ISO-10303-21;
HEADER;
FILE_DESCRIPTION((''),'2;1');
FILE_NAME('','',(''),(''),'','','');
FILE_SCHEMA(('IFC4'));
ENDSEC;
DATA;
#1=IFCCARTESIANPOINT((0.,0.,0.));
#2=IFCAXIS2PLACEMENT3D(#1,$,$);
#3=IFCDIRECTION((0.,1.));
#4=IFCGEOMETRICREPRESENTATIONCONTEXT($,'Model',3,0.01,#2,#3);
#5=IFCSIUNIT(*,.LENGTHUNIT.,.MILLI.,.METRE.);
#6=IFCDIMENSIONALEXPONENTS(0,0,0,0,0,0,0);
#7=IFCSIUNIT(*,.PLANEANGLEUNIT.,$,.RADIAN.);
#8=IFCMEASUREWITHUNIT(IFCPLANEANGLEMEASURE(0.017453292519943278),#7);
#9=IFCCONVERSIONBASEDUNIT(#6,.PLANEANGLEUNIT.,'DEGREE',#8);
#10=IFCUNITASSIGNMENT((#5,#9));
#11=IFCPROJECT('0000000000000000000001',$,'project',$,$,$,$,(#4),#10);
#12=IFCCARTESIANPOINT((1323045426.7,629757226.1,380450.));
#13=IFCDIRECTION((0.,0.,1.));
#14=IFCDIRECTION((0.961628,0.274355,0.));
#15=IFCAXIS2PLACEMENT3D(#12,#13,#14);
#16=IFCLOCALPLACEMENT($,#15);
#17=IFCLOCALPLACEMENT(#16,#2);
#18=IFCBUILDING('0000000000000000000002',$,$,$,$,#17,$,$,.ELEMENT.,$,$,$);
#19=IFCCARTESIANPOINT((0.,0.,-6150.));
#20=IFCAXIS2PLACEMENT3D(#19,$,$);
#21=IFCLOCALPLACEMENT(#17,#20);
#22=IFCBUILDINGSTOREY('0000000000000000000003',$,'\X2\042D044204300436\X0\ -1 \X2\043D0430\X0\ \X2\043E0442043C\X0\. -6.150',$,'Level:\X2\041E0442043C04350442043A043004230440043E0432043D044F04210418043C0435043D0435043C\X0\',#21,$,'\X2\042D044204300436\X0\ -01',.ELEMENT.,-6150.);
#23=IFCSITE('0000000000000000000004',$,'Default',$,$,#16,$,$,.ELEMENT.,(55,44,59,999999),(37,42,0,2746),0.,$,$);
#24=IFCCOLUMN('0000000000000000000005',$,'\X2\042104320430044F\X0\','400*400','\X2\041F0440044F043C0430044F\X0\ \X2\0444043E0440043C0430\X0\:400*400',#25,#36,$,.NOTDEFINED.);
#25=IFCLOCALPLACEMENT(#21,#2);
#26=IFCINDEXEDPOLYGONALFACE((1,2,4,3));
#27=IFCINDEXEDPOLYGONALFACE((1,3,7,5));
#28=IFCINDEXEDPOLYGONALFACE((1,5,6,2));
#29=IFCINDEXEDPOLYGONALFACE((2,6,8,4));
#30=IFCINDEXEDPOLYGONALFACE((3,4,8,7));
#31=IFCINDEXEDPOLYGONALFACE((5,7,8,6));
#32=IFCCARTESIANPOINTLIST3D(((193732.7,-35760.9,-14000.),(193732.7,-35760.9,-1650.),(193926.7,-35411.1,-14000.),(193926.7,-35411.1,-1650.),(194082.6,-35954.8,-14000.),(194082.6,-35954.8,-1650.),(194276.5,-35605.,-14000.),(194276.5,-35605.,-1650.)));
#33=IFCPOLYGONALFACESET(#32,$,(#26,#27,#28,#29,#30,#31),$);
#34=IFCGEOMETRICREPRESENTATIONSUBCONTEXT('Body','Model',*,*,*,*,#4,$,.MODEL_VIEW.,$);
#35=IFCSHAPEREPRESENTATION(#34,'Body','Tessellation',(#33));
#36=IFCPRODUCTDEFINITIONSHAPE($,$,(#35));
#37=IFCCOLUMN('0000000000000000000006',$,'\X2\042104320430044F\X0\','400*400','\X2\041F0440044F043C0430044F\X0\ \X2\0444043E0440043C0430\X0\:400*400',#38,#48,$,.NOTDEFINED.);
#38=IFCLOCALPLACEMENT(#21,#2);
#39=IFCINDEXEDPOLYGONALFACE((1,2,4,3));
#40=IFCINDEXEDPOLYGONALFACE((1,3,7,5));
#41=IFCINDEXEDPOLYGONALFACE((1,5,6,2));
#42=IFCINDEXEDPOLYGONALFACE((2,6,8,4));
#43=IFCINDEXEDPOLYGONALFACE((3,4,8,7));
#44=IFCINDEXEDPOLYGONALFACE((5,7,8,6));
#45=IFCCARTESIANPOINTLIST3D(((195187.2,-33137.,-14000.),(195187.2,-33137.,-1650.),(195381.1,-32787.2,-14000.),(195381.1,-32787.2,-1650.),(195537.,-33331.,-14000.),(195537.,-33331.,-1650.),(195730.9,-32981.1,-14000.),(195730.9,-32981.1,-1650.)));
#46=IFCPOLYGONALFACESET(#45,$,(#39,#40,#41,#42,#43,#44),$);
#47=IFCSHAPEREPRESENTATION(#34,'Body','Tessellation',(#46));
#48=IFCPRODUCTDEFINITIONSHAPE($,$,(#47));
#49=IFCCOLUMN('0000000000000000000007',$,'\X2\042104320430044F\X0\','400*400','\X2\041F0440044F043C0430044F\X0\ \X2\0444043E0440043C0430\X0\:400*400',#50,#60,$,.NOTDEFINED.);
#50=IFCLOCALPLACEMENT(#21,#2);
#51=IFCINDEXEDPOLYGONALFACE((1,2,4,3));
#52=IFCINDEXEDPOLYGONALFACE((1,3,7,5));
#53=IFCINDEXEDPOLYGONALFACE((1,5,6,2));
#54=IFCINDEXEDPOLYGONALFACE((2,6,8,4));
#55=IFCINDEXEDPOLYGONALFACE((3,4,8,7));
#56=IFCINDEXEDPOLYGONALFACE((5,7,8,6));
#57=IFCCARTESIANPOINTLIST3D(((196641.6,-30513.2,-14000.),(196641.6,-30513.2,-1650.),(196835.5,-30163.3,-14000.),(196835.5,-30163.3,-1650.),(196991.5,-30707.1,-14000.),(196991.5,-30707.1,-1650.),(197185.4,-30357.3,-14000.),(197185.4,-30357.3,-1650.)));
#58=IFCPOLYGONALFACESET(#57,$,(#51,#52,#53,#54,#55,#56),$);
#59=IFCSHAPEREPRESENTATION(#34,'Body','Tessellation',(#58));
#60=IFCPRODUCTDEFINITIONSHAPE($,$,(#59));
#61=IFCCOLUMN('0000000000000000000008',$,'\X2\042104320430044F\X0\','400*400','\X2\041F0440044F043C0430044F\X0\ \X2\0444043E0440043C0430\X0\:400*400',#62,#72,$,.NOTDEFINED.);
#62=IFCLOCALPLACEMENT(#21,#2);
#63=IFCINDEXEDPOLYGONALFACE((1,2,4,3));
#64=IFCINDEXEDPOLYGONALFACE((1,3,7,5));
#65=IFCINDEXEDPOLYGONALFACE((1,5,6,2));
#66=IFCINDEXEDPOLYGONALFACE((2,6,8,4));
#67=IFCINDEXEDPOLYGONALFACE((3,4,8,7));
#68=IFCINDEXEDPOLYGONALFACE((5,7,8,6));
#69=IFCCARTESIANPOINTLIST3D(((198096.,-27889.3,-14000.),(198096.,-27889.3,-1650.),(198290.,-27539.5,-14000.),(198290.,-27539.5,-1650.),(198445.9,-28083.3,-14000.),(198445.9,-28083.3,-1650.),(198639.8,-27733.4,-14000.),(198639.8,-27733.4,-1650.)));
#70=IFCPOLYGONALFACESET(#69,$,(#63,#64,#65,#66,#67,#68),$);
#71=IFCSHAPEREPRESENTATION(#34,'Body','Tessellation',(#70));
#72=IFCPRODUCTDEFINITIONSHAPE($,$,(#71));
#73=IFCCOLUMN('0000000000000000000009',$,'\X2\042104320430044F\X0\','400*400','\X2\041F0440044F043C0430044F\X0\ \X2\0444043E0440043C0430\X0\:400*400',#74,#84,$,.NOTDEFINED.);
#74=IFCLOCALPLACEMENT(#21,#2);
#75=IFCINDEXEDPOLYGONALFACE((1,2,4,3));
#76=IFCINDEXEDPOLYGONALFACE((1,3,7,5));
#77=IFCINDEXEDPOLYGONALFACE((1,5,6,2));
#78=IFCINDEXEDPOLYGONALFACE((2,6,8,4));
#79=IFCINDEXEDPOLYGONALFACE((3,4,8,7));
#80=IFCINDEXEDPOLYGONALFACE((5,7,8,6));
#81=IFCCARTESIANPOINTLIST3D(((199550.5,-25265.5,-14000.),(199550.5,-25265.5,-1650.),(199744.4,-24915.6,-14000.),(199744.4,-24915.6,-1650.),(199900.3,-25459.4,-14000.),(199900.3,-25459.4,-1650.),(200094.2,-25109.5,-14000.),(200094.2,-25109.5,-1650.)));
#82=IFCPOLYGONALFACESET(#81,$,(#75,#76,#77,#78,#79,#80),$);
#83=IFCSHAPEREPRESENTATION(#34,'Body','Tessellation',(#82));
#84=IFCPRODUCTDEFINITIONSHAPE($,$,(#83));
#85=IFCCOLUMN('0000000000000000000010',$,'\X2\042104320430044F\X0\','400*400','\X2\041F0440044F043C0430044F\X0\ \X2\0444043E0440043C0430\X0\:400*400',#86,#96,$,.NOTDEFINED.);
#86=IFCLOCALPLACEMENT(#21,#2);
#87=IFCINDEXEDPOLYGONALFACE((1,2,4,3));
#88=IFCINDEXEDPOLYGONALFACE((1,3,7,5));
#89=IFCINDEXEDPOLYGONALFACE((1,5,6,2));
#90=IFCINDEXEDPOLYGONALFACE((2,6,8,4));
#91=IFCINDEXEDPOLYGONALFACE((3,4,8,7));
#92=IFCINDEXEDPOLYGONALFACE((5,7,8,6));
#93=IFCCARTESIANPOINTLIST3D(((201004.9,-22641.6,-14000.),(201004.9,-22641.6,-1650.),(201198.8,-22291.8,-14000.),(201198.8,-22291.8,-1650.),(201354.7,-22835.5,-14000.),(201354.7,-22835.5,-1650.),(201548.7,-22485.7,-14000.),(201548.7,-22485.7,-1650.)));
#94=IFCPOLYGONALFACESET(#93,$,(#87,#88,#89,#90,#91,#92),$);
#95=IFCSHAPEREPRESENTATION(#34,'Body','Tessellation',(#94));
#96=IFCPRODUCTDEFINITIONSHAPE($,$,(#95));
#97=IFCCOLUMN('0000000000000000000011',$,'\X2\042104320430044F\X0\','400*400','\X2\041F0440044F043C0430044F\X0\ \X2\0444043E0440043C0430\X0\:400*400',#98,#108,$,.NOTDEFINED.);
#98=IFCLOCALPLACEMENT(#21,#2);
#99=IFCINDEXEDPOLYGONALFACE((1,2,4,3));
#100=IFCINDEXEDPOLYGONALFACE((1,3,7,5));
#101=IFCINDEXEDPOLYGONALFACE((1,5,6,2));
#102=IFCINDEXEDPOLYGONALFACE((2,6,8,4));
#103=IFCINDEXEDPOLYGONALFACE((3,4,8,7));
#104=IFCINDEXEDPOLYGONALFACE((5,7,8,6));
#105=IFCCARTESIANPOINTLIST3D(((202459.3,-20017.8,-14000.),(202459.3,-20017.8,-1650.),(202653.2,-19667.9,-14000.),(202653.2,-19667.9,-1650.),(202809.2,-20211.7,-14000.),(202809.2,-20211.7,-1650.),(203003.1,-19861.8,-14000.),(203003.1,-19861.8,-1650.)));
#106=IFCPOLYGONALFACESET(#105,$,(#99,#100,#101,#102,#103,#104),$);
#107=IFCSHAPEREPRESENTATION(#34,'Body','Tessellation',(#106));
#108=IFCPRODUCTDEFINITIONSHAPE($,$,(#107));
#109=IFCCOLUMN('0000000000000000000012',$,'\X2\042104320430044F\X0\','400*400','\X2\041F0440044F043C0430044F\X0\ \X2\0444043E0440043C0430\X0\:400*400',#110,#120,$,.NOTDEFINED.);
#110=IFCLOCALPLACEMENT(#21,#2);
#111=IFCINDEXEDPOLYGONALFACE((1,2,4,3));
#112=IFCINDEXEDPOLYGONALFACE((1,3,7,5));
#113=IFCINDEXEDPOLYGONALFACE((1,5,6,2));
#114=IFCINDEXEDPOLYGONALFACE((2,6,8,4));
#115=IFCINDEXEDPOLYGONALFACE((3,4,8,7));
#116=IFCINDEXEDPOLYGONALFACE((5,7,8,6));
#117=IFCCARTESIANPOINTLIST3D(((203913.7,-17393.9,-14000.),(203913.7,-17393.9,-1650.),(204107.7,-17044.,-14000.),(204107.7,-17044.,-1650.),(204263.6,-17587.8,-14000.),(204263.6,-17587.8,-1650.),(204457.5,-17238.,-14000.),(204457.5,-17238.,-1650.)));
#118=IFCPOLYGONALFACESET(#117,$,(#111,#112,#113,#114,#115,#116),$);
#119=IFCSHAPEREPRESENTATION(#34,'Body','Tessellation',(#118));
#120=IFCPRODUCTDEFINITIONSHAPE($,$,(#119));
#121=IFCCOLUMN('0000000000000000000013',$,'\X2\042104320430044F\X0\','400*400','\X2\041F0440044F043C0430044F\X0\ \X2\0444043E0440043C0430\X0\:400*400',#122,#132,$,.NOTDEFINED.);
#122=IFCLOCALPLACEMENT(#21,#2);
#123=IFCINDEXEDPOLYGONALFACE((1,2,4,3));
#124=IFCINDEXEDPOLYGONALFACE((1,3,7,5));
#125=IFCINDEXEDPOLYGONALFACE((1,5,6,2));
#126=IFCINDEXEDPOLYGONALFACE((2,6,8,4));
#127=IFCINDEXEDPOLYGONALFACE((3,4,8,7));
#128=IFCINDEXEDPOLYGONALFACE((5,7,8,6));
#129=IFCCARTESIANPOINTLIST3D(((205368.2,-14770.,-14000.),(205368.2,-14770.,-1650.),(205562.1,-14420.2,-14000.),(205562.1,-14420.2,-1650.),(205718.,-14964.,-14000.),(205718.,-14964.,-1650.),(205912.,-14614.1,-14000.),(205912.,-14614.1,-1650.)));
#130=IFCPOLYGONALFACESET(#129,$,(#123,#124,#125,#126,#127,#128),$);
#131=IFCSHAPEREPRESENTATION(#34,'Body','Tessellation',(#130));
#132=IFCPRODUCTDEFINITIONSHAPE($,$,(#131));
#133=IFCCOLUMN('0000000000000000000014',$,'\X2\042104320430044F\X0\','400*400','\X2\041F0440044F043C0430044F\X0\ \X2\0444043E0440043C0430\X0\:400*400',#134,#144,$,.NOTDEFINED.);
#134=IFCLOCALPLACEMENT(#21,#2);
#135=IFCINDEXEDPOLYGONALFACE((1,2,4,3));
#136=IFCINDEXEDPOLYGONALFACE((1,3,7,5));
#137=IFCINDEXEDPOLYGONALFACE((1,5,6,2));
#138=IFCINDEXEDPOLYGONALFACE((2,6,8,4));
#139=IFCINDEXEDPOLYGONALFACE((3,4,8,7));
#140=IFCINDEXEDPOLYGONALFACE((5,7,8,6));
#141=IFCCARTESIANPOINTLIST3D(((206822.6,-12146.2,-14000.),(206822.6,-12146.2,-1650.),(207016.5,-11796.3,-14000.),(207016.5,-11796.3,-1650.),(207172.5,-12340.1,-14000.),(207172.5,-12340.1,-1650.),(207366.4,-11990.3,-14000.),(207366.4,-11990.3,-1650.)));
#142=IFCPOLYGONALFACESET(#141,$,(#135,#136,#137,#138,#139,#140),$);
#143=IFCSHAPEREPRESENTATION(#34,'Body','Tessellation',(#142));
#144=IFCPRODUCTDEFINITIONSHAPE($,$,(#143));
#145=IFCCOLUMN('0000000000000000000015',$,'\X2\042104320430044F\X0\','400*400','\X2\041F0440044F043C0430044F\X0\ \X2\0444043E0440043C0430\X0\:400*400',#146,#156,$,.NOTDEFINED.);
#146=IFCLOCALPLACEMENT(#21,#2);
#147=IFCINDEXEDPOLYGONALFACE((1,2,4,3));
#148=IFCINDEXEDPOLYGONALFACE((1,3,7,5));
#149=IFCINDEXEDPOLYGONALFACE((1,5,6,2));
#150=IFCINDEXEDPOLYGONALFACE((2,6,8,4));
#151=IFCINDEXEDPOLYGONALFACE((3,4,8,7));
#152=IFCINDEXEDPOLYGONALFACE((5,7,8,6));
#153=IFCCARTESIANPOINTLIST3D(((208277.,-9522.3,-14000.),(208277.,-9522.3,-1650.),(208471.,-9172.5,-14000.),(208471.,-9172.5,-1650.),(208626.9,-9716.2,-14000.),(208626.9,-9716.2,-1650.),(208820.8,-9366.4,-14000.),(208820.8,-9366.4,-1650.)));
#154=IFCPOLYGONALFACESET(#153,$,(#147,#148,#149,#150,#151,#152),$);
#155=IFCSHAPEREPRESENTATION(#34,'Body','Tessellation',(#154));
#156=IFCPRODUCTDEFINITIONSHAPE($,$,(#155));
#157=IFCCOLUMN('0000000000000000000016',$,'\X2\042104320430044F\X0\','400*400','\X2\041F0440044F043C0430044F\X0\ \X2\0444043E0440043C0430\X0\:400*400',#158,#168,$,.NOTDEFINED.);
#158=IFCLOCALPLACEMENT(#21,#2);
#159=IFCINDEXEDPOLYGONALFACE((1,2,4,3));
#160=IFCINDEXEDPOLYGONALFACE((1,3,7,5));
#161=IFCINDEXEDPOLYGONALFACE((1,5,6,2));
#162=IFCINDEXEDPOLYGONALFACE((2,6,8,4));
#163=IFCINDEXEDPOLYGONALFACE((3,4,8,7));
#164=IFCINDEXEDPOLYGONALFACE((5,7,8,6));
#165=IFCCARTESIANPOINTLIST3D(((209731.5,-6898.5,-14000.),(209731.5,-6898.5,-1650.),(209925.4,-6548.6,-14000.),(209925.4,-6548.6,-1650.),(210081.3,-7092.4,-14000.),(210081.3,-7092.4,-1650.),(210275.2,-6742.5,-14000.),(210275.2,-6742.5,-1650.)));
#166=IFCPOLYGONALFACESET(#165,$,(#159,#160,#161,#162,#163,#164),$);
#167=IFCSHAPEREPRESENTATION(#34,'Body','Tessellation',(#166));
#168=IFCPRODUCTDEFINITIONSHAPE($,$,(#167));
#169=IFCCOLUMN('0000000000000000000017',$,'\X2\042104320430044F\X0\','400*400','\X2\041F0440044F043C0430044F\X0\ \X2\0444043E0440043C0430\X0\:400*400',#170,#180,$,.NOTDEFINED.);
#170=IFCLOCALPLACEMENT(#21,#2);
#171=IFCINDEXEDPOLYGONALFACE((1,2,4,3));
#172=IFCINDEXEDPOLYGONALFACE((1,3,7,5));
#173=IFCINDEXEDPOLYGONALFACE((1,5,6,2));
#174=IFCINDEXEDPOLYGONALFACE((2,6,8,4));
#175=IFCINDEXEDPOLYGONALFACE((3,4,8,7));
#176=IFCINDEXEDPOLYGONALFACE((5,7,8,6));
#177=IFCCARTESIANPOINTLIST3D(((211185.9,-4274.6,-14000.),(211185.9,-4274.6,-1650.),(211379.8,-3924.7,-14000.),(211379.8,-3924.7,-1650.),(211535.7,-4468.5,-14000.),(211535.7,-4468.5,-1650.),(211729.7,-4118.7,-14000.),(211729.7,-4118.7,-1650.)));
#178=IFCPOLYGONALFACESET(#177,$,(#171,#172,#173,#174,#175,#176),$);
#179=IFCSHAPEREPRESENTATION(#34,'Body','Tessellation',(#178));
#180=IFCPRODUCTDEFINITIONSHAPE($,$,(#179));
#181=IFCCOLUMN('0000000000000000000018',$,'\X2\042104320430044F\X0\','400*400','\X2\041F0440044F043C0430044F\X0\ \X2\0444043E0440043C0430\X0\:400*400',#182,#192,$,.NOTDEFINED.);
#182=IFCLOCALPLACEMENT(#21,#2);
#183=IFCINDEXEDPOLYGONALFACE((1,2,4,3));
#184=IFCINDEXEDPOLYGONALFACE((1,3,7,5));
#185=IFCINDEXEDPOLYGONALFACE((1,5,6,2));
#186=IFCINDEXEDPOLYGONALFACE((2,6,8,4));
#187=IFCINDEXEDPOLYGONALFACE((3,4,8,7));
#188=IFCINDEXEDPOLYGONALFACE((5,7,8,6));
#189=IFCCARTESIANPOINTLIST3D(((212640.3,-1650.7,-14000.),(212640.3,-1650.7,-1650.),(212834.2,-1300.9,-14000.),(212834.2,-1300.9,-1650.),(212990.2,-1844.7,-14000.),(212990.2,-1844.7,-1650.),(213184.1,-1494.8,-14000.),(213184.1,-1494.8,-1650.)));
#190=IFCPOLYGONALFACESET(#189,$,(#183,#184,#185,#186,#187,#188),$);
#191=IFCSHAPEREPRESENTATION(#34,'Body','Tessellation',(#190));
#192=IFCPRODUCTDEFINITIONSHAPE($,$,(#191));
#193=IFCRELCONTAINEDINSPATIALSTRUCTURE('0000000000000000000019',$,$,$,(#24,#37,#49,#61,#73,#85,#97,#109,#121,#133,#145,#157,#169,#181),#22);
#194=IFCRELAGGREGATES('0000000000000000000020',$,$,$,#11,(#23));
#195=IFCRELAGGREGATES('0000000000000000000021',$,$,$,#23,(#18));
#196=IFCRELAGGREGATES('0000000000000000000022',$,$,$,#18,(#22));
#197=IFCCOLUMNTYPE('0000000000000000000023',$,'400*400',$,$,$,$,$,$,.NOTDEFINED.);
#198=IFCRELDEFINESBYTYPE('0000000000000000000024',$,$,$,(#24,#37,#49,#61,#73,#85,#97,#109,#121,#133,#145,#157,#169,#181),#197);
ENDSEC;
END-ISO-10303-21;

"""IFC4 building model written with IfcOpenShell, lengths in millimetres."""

from ifc_helpers import new_model, entity, si_unit, converted_unit, direction, frame, origin, place, context, subcontext, project, spatial, indexed_curve, outline, extrude, type_object, element, save


model = new_model("IFC4")

# Units and contexts
model_context = context("Model", 3, precision=0.01, world=origin(), true_north=direction((0.0, 1.0)))
body_context = subcontext(model_context, "Body", "Model", "MODEL_VIEW")
ifc_project = project(units=[si_unit("LENGTHUNIT", "METRE", prefix="MILLI"), converted_unit("PLANEANGLEUNIT", "DEGREE", entity("IfcPlaneAngleMeasure", 0.017453292519943278), si_unit("PLANEANGLEUNIT", "RADIAN"), dimensions=[0, 0, 0, 0, 0, 0, 0])], contexts=[model_context])

# Site, building, storey
site_placement = place(None, frame((1323045426.7, 629757226.1, 380450.0), z_axis=(0.0, 0.0, 1.0), x_axis=(0.961628, 0.274355, 0.0)))
site = spatial("IfcSite", under=ifc_project, at=site_placement, Name="Default", CompositionType="ELEMENT", RefLatitude=(55, 44, 59, 999999), RefLongitude=(37, 42, 0, 2746), RefElevation=0.0)
building_placement = place(site_placement, origin())
building = spatial("IfcBuilding", under=site, at=building_placement, CompositionType="ELEMENT")
storey_placement = place(building_placement, frame((0.0, 0.0, -6150.0)))
storey = spatial("IfcBuildingStorey", under=building, at=storey_placement, Name="Этаж -1 на отм. -6.150", ObjectType="Level:ОтметкаУровняСИменем", LongName="Этаж -01", CompositionType="ELEMENT", Elevation=-6150.0)

# Columns
column_type = type_object("IfcColumnType", Name="400*400", PredefinedType="NOTDEFINED")
column_1_placement = place(storey_placement, origin())
element("IfcColumn", 1, at=column_1_placement, inside=storey, type_object=column_type, Name="Свая", Description="400*400", ObjectType="Прямая форма:400*400", PredefinedType="NOTDEFINED", context=body_context, shape_type="SweptSolid", body=[
    extrude(outline(indexed_curve([(-200.0, -200.0), (200.0, -200.0), (200.0, 200.0), (-200.0, 200.0), (-200.0, -200.0)], self_intersect=False)), frame((194004.6, -35682.9, -14000.0), z_axis=(0.0, 0.0, 1.0), x_axis=(0.48481, 0.87462, 0.0)), (0.0, 0.0, 1.0), 12350.0),
])
column_2_placement = place(storey_placement, origin())
element("IfcColumn", 2, at=column_2_placement, inside=storey, type_object=column_type, Name="Свая", Description="400*400", ObjectType="Прямая форма:400*400", PredefinedType="NOTDEFINED", context=body_context, shape_type="SweptSolid", body=[
    extrude(outline(indexed_curve([(-200.0, -200.0), (200.0, -200.0), (200.0, 200.0), (-200.0, 200.0), (-200.0, -200.0)], self_intersect=False)), frame((195459.1, -33059.1, -14000.0), z_axis=(0.0, 0.0, 1.0), x_axis=(0.48481, 0.87462, 0.0)), (0.0, 0.0, 1.0), 12350.0),
])
column_3_placement = place(storey_placement, origin())
element("IfcColumn", 3, at=column_3_placement, inside=storey, type_object=column_type, Name="Свая", Description="400*400", ObjectType="Прямая форма:400*400", PredefinedType="NOTDEFINED", context=body_context, shape_type="SweptSolid", body=[
    extrude(outline(indexed_curve([(-200.0, -200.0), (200.0, -200.0), (200.0, 200.0), (-200.0, 200.0), (-200.0, -200.0)], self_intersect=False)), frame((196913.5, -30435.2, -14000.0), z_axis=(0.0, 0.0, 1.0), x_axis=(0.48481, 0.87462, 0.0)), (0.0, 0.0, 1.0), 12350.0),
])
column_4_placement = place(storey_placement, origin())
element("IfcColumn", 4, at=column_4_placement, inside=storey, type_object=column_type, Name="Свая", Description="400*400", ObjectType="Прямая форма:400*400", PredefinedType="NOTDEFINED", context=body_context, shape_type="SweptSolid", body=[
    extrude(outline(indexed_curve([(-200.0, -200.0), (200.0, -200.0), (200.0, 200.0), (-200.0, 200.0), (-200.0, -200.0)], self_intersect=False)), frame((198367.9, -27811.4, -14000.0), z_axis=(0.0, 0.0, 1.0), x_axis=(0.48481, 0.87462, 0.0)), (0.0, 0.0, 1.0), 12350.0),
])
column_5_placement = place(storey_placement, origin())
element("IfcColumn", 5, at=column_5_placement, inside=storey, type_object=column_type, Name="Свая", Description="400*400", ObjectType="Прямая форма:400*400", PredefinedType="NOTDEFINED", context=body_context, shape_type="SweptSolid", body=[
    extrude(outline(indexed_curve([(-200.0, -200.0), (200.0, -200.0), (200.0, 200.0), (-200.0, 200.0), (-200.0, -200.0)], self_intersect=False)), frame((199822.3, -25187.5, -14000.0), z_axis=(0.0, 0.0, 1.0), x_axis=(0.48481, 0.87462, 0.0)), (0.0, 0.0, 1.0), 12350.0),
])
column_6_placement = place(storey_placement, origin())
element("IfcColumn", 6, at=column_6_placement, inside=storey, type_object=column_type, Name="Свая", Description="400*400", ObjectType="Прямая форма:400*400", PredefinedType="NOTDEFINED", context=body_context, shape_type="SweptSolid", body=[
    extrude(outline(indexed_curve([(-200.0, -200.0), (200.0, -200.0), (200.0, 200.0), (-200.0, 200.0), (-200.0, -200.0)], self_intersect=False)), frame((201276.8, -22563.6, -14000.0), z_axis=(0.0, 0.0, 1.0), x_axis=(0.48481, 0.87462, 0.0)), (0.0, 0.0, 1.0), 12350.0),
])
column_7_placement = place(storey_placement, origin())
element("IfcColumn", 7, at=column_7_placement, inside=storey, type_object=column_type, Name="Свая", Description="400*400", ObjectType="Прямая форма:400*400", PredefinedType="NOTDEFINED", context=body_context, shape_type="SweptSolid", body=[
    extrude(outline(indexed_curve([(-200.0, -200.0), (200.0, -200.0), (200.0, 200.0), (-200.0, 200.0), (-200.0, -200.0)], self_intersect=False)), frame((202731.2, -19939.8, -14000.0), z_axis=(0.0, 0.0, 1.0), x_axis=(0.48481, 0.87462, 0.0)), (0.0, 0.0, 1.0), 12350.0),
])
column_8_placement = place(storey_placement, origin())
element("IfcColumn", 8, at=column_8_placement, inside=storey, type_object=column_type, Name="Свая", Description="400*400", ObjectType="Прямая форма:400*400", PredefinedType="NOTDEFINED", context=body_context, shape_type="SweptSolid", body=[
    extrude(outline(indexed_curve([(-200.0, -200.0), (200.0, -200.0), (200.0, 200.0), (-200.0, 200.0), (-200.0, -200.0)], self_intersect=False)), frame((204185.6, -17315.9, -14000.0), z_axis=(0.0, 0.0, 1.0), x_axis=(0.48481, 0.87462, 0.0)), (0.0, 0.0, 1.0), 12350.0),
])
column_9_placement = place(storey_placement, origin())
element("IfcColumn", 9, at=column_9_placement, inside=storey, type_object=column_type, Name="Свая", Description="400*400", ObjectType="Прямая форма:400*400", PredefinedType="NOTDEFINED", context=body_context, shape_type="SweptSolid", body=[
    extrude(outline(indexed_curve([(-200.0, -200.0), (200.0, -200.0), (200.0, 200.0), (-200.0, 200.0), (-200.0, -200.0)], self_intersect=False)), frame((205640.1, -14692.1, -14000.0), z_axis=(0.0, 0.0, 1.0), x_axis=(0.48481, 0.87462, 0.0)), (0.0, 0.0, 1.0), 12350.0),
])
column_10_placement = place(storey_placement, origin())
element("IfcColumn", 10, at=column_10_placement, inside=storey, type_object=column_type, Name="Свая", Description="400*400", ObjectType="Прямая форма:400*400", PredefinedType="NOTDEFINED", context=body_context, shape_type="SweptSolid", body=[
    extrude(outline(indexed_curve([(-200.0, -200.0), (200.0, -200.0), (200.0, 200.0), (-200.0, 200.0), (-200.0, -200.0)], self_intersect=False)), frame((207094.5, -12068.2, -14000.0), z_axis=(0.0, 0.0, 1.0), x_axis=(0.48481, 0.87462, 0.0)), (0.0, 0.0, 1.0), 12350.0),
])
column_11_placement = place(storey_placement, origin())
element("IfcColumn", 11, at=column_11_placement, inside=storey, type_object=column_type, Name="Свая", Description="400*400", ObjectType="Прямая форма:400*400", PredefinedType="NOTDEFINED", context=body_context, shape_type="SweptSolid", body=[
    extrude(outline(indexed_curve([(-200.0, -200.0), (200.0, -200.0), (200.0, 200.0), (-200.0, 200.0), (-200.0, -200.0)], self_intersect=False)), frame((208548.9, -9444.4, -14000.0), z_axis=(0.0, 0.0, 1.0), x_axis=(0.48481, 0.87462, 0.0)), (0.0, 0.0, 1.0), 12350.0),
])
column_12_placement = place(storey_placement, origin())
element("IfcColumn", 12, at=column_12_placement, inside=storey, type_object=column_type, Name="Свая", Description="400*400", ObjectType="Прямая форма:400*400", PredefinedType="NOTDEFINED", context=body_context, shape_type="SweptSolid", body=[
    extrude(outline(indexed_curve([(-200.0, -200.0), (200.0, -200.0), (200.0, 200.0), (-200.0, 200.0), (-200.0, -200.0)], self_intersect=False)), frame((210003.4, -6820.5, -14000.0), z_axis=(0.0, 0.0, 1.0), x_axis=(0.48481, 0.87462, 0.0)), (0.0, 0.0, 1.0), 12350.0),
])
column_13_placement = place(storey_placement, origin())
element("IfcColumn", 13, at=column_13_placement, inside=storey, type_object=column_type, Name="Свая", Description="400*400", ObjectType="Прямая форма:400*400", PredefinedType="NOTDEFINED", context=body_context, shape_type="SweptSolid", body=[
    extrude(outline(indexed_curve([(-200.0, -200.0), (200.0, -200.0), (200.0, 200.0), (-200.0, 200.0), (-200.0, -200.0)], self_intersect=False)), frame((211457.8, -4196.6, -14000.0), z_axis=(0.0, 0.0, 1.0), x_axis=(0.48481, 0.87462, 0.0)), (0.0, 0.0, 1.0), 12350.0),
])
column_14_placement = place(storey_placement, origin())
element("IfcColumn", 14, at=column_14_placement, inside=storey, type_object=column_type, Name="Свая", Description="400*400", ObjectType="Прямая форма:400*400", PredefinedType="NOTDEFINED", context=body_context, shape_type="SweptSolid", body=[
    extrude(outline(indexed_curve([(-200.0, -200.0), (200.0, -200.0), (200.0, 200.0), (-200.0, 200.0), (-200.0, -200.0)], self_intersect=False)), frame((212912.2, -1572.8, -14000.0), z_axis=(0.0, 0.0, 1.0), x_axis=(0.48481, 0.87462, 0.0)), (0.0, 0.0, 1.0), 12350.0),
])

save(model, "model.ifc")
